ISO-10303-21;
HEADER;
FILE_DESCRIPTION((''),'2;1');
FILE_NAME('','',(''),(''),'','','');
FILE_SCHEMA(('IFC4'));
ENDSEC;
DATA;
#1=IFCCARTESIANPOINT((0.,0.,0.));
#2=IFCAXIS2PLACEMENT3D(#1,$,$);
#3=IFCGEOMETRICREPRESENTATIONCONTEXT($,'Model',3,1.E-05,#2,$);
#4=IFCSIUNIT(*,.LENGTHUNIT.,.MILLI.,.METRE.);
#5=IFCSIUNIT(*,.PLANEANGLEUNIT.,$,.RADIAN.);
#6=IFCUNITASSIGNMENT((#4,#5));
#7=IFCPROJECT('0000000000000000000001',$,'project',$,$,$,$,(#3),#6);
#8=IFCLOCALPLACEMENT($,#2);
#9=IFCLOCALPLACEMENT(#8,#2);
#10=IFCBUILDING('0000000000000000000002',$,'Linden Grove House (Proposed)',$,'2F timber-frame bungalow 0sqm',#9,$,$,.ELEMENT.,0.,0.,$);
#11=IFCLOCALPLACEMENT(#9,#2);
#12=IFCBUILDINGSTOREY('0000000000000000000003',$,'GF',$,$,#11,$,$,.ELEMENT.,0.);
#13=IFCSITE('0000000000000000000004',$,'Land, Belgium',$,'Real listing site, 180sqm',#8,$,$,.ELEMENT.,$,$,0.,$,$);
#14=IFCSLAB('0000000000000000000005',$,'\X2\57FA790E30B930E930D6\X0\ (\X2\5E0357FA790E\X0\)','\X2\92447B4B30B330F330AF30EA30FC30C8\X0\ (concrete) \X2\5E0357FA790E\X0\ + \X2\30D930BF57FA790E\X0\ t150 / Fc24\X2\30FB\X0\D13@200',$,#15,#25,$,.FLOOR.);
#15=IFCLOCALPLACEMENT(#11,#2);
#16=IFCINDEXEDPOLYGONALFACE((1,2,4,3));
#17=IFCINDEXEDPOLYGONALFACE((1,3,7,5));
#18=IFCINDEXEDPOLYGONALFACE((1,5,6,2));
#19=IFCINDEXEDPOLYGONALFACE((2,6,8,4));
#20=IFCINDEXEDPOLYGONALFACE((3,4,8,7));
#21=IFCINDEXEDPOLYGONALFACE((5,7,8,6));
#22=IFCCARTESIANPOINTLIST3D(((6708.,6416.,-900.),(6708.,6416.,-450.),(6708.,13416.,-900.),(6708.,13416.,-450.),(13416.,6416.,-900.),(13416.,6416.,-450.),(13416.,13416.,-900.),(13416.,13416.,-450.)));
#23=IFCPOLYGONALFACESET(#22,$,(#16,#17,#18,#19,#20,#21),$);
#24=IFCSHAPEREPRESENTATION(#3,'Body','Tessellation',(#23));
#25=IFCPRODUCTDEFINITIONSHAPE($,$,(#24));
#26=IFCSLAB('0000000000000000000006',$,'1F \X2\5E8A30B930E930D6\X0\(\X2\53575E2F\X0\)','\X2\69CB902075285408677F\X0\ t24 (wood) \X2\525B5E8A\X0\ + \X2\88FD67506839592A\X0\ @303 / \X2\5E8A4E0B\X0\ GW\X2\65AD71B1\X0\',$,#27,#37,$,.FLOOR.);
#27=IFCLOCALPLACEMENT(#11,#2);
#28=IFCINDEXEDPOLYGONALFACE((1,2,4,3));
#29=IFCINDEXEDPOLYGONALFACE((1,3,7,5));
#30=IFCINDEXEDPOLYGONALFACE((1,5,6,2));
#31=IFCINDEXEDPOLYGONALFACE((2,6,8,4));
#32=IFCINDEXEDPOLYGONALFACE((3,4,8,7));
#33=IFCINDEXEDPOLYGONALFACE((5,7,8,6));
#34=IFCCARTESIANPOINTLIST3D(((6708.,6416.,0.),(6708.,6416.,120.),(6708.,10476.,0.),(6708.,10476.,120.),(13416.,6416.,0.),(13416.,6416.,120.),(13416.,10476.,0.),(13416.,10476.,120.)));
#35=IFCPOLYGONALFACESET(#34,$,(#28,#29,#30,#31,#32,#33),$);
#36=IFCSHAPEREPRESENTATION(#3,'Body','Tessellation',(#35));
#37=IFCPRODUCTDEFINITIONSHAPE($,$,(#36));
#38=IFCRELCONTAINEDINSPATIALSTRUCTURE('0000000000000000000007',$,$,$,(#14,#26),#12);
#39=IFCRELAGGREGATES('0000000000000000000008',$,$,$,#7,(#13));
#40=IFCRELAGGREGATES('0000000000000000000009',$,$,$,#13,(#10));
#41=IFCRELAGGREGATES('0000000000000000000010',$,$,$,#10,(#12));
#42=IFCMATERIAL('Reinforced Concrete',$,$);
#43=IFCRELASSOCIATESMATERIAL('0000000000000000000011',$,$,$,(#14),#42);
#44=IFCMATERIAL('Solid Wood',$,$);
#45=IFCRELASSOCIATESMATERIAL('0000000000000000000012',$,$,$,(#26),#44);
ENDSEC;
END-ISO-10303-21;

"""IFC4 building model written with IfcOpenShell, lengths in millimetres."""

from ifc_helpers import new_model, si_unit, frame, frame_2d, origin, place, context, project, spatial, rectangle, extrude, material, element, save


model = new_model("IFC4")

# Units and contexts
model_context = context("Model", 3, precision=1e-05, world=origin())
ifc_project = project(units=[si_unit("LENGTHUNIT", "METRE", prefix="MILLI"), si_unit("PLANEANGLEUNIT", "RADIAN")], contexts=[model_context])

# Site, building, storey
site_placement = place(None, origin())
site = spatial("IfcSite", under=ifc_project, at=site_placement, Name="Land, Belgium", ObjectType="Real listing site, 180sqm", CompositionType="ELEMENT", RefElevation=0.0)
building_placement = place(site_placement, origin())
building = spatial("IfcBuilding", under=site, at=building_placement, Name="Linden Grove House (Proposed)", ObjectType="2F timber-frame bungalow 0sqm", CompositionType="ELEMENT", ElevationOfRefHeight=0.0, ElevationOfTerrain=0.0)
storey_placement = place(building_placement, origin())
storey = spatial("IfcBuildingStorey", under=building, at=storey_placement, Name="GF", CompositionType="ELEMENT", Elevation=0.0)

# Slabs
ifc_material_1 = material(Name="Reinforced Concrete")
slab_1_placement = place(storey_placement, frame((3354.0, 3208.0, -450.0)))
element("IfcSlab", 1, at=slab_1_placement, inside=storey, material=ifc_material_1, Name="基礎スラブ (布基礎)", Description="鉄筋コンクリート (concrete) 布基礎 + ベタ基礎 t150 / Fc24・D13@200", PredefinedType="FLOOR", context=model_context, shape_type="SweptSolid", body=[
    extrude(rectangle(XDim=6708.0, YDim=7000.0, at=frame_2d((3354.0, 3500.0))), frame((3354.0, 3208.0, -450.0)), (0.0, 0.0, 1.0), 450.0),
])
ifc_material_2 = material(Name="Solid Wood")
slab_2_placement = place(storey_placement, frame((3354.0, 3208.0, 0.0)))
element("IfcSlab", 2, at=slab_2_placement, inside=storey, material=ifc_material_2, Name="1F 床スラブ(南帯)", Description="構造用合板 t24 (wood) 剛床 + 製材根太 @303 / 床下 GW断熱", PredefinedType="FLOOR", context=model_context, shape_type="SweptSolid", body=[
    extrude(rectangle(XDim=6708.0, YDim=4060.0, at=frame_2d((3354.0, 2030.0))), frame((3354.0, 3208.0, 0.0)), (0.0, 0.0, 1.0), 120.0),
])

save(model, "model.ifc")
